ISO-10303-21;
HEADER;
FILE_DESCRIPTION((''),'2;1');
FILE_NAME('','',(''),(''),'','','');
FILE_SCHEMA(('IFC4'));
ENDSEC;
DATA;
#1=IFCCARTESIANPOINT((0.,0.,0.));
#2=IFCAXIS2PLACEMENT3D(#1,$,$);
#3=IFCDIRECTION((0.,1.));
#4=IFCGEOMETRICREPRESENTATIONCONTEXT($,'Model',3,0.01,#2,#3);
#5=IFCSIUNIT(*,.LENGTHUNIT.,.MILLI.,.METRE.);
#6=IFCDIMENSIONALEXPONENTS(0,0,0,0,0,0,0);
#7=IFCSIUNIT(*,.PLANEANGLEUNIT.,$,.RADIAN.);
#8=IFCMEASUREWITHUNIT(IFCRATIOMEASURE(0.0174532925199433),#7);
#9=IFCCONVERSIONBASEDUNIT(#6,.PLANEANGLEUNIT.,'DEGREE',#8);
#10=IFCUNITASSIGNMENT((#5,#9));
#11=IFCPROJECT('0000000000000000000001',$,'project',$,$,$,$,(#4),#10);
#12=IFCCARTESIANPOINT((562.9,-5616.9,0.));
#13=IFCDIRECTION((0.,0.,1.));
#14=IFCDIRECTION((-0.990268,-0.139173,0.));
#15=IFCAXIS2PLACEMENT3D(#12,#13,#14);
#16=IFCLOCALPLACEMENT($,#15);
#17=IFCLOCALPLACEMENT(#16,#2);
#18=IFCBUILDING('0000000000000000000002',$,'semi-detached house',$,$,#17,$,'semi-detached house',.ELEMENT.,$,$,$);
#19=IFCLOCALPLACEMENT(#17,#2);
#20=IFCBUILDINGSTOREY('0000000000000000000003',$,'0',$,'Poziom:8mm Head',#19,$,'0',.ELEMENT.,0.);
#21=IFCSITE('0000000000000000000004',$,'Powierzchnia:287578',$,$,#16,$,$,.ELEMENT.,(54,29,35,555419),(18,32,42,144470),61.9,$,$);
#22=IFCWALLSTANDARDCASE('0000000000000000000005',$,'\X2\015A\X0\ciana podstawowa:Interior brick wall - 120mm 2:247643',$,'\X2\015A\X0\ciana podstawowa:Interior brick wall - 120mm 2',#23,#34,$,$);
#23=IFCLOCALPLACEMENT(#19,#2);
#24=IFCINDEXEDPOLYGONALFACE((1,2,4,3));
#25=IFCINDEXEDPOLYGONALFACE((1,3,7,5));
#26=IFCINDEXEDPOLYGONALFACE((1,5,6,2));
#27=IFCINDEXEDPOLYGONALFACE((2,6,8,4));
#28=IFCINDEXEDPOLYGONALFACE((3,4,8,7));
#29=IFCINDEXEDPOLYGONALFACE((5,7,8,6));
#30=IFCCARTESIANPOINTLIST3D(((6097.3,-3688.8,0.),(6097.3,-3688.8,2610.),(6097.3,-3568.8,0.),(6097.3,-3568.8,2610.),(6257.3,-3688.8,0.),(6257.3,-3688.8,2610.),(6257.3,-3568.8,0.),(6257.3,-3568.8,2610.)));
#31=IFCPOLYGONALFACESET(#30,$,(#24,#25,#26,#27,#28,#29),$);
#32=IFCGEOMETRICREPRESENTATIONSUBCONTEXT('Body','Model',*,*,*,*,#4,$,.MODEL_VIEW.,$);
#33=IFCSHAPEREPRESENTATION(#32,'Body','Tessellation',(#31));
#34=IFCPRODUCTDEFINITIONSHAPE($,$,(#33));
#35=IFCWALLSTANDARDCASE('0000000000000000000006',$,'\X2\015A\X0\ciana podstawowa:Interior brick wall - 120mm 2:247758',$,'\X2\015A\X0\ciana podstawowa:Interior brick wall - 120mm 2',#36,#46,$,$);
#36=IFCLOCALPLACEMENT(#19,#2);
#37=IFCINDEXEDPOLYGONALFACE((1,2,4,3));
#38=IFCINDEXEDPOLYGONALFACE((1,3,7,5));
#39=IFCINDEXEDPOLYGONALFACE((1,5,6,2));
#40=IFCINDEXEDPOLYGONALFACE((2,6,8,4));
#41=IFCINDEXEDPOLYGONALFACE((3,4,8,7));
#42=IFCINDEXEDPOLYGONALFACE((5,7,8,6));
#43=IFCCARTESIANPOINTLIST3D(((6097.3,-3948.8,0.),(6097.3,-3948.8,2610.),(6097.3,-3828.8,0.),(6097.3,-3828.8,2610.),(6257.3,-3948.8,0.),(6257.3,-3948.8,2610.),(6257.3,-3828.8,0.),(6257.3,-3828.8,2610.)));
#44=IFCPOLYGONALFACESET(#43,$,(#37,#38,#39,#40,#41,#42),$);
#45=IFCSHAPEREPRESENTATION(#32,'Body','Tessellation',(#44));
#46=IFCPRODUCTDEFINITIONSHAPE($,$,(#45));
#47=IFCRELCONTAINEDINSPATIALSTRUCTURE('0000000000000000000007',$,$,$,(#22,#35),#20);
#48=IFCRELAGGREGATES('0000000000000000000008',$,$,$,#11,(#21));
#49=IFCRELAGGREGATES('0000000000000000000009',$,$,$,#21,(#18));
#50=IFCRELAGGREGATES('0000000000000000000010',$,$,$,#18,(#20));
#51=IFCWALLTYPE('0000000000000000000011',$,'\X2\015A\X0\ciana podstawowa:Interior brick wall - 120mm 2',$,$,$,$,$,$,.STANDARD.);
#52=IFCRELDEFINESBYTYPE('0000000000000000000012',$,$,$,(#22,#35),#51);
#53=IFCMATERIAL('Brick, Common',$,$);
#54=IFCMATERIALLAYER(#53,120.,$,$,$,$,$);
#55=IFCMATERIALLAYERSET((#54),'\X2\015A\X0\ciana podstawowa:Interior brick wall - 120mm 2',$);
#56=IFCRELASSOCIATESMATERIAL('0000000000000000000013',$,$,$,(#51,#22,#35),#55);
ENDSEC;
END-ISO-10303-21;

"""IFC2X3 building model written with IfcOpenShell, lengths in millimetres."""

from ifc_helpers import new_model, entity, si_unit, converted_unit, direction, frame, frame_2d, origin, place, context, subcontext, project, spatial, polyline, rectangle, extrude, clip, bounded_halfspace, material, layer, layer_set, layer_usage, type_object, element, save


model = new_model("IFC2X3")

# Units and contexts
model_context = context("Model", 3, precision=0.01, world=origin(), true_north=direction((0.0, 1.0)))
body_context = subcontext(model_context, "Body", "Model", "MODEL_VIEW")
ifc_project = project(units=[si_unit("LENGTHUNIT", "METRE", prefix="MILLI"), converted_unit("PLANEANGLEUNIT", "DEGREE", entity("IfcRatioMeasure", 0.0174532925199433), si_unit("PLANEANGLEUNIT", "RADIAN"), dimensions=[0, 0, 0, 0, 0, 0, 0])], contexts=[model_context])

# Site, building, storey
site_placement = place(None, frame((562.9, -5616.9, 0.0), z_axis=(0.0, 0.0, 1.0), x_axis=(-0.990268, -0.139173, 0.0)))
site = spatial("IfcSite", under=ifc_project, at=site_placement, Name="Powierzchnia:287578", CompositionType="ELEMENT", RefLatitude=(54, 29, 35, 555419), RefLongitude=(18, 32, 42, 144470), RefElevation=61.9)
building_placement = place(site_placement, origin())
building = spatial("IfcBuilding", under=site, at=building_placement, Name="semi-detached house", LongName="semi-detached house", CompositionType="ELEMENT")
storey_placement = place(building_placement, origin())
storey = spatial("IfcBuildingStorey", under=building, at=storey_placement, Name="0", ObjectType="Poziom:8mm Head", LongName="0", CompositionType="ELEMENT", Elevation=0.0)

# Shared definitions
ifc_material_1 = material(Name="Brick, Common")

# Walls
ifc_layer_1 = layer(ifc_material_1, 120.0)
ifc_layer_set_1 = layer_set([ifc_layer_1], Name="Ściana podstawowa:Interior brick wall - 120mm 2")
wall_type_1 = type_object("IfcWallType", Name="Ściana podstawowa:Interior brick wall - 120mm 2", PredefinedType="STANDARD", material=ifc_layer_set_1)
ifc_layer_usage_1 = layer_usage(ifc_layer_set_1, "AXIS2", "NEGATIVE", 60.0)
wall_1_placement = place(storey_placement, frame((6097.3, -3628.8, 0.0)))
element("IfcWallStandardCase", 1, at=wall_1_placement, inside=storey, type_object=wall_type_1, material=ifc_layer_usage_1, Name="Ściana podstawowa:Interior brick wall - 120mm 2:247643", ObjectType="Ściana podstawowa:Interior brick wall - 120mm 2", context=body_context, shape_type="Clipping", body=[
    clip(clip(extrude(rectangle(XDim=160.0, YDim=120.0, at=frame_2d((80.0, 0.0), x_axis=(-1.0, 0.0))), origin(), (0.0, 0.0, 1.0), 2610.0), bounded_halfspace(frame((0.0, -60.0, 2610.0), z_axis=(0.0, 0.0, -1.0), x_axis=(1.0, 0.0, 0.0)), True, frame((0.0, -60.0, 2610.0)), polyline([(0.0, 0.0), (160.0, 0.0), (160.0, 120.0), (0.0, 120.0), (0.0, 0.0)]))), bounded_halfspace(frame((160.0, -60.0, 0.0), z_axis=(0.0, 0.0, 1.0), x_axis=(0.0, -1.0, 0.0)), True, frame((160.0, -60.0, 0.0), z_axis=(0.0, 0.0, 1.0), x_axis=(0.0, -1.0, 0.0)), polyline([(0.0, 0.0), (-120.0, 0.0), (-120.0, -2.6), (-120.0, -146.0), (-120.0, -160.0), (0.0, -160.0), (0.0, -2.6), (0.0, 0.0)]))),
])
ifc_layer_usage_2 = layer_usage(ifc_layer_set_1, "AXIS2", "NEGATIVE", 60.0)
wall_2_placement = place(storey_placement, frame((6097.3, -3888.8, 0.0)))
element("IfcWallStandardCase", 2, at=wall_2_placement, inside=storey, type_object=wall_type_1, material=ifc_layer_usage_2, Name="Ściana podstawowa:Interior brick wall - 120mm 2:247758", ObjectType="Ściana podstawowa:Interior brick wall - 120mm 2", context=body_context, shape_type="Clipping", body=[
    clip(clip(extrude(rectangle(XDim=160.0, YDim=120.0, at=frame_2d((80.0, 0.0), x_axis=(-1.0, 0.0))), origin(), (0.0, 0.0, 1.0), 2610.0), bounded_halfspace(frame((0.0, -60.0, 2610.0), z_axis=(0.0, 0.0, -1.0), x_axis=(1.0, 0.0, 0.0)), True, frame((0.0, -60.0, 2610.0)), polyline([(0.0, 0.0), (160.0, 0.0), (160.0, 120.0), (0.0, 120.0), (0.0, 0.0)]))), bounded_halfspace(frame((160.0, -60.0, 0.0), z_axis=(0.0, 0.0, 1.0), x_axis=(0.0, -1.0, 0.0)), True, frame((160.0, -60.0, 0.0), z_axis=(0.0, 0.0, 1.0), x_axis=(0.0, -1.0, 0.0)), polyline([(0.0, 0.0), (-120.0, 0.0), (-120.0, -2.6), (-120.0, -146.0), (-120.0, -160.0), (0.0, -160.0), (0.0, -2.6), (0.0, 0.0)]))),
])

save(model, "model.ifc")
